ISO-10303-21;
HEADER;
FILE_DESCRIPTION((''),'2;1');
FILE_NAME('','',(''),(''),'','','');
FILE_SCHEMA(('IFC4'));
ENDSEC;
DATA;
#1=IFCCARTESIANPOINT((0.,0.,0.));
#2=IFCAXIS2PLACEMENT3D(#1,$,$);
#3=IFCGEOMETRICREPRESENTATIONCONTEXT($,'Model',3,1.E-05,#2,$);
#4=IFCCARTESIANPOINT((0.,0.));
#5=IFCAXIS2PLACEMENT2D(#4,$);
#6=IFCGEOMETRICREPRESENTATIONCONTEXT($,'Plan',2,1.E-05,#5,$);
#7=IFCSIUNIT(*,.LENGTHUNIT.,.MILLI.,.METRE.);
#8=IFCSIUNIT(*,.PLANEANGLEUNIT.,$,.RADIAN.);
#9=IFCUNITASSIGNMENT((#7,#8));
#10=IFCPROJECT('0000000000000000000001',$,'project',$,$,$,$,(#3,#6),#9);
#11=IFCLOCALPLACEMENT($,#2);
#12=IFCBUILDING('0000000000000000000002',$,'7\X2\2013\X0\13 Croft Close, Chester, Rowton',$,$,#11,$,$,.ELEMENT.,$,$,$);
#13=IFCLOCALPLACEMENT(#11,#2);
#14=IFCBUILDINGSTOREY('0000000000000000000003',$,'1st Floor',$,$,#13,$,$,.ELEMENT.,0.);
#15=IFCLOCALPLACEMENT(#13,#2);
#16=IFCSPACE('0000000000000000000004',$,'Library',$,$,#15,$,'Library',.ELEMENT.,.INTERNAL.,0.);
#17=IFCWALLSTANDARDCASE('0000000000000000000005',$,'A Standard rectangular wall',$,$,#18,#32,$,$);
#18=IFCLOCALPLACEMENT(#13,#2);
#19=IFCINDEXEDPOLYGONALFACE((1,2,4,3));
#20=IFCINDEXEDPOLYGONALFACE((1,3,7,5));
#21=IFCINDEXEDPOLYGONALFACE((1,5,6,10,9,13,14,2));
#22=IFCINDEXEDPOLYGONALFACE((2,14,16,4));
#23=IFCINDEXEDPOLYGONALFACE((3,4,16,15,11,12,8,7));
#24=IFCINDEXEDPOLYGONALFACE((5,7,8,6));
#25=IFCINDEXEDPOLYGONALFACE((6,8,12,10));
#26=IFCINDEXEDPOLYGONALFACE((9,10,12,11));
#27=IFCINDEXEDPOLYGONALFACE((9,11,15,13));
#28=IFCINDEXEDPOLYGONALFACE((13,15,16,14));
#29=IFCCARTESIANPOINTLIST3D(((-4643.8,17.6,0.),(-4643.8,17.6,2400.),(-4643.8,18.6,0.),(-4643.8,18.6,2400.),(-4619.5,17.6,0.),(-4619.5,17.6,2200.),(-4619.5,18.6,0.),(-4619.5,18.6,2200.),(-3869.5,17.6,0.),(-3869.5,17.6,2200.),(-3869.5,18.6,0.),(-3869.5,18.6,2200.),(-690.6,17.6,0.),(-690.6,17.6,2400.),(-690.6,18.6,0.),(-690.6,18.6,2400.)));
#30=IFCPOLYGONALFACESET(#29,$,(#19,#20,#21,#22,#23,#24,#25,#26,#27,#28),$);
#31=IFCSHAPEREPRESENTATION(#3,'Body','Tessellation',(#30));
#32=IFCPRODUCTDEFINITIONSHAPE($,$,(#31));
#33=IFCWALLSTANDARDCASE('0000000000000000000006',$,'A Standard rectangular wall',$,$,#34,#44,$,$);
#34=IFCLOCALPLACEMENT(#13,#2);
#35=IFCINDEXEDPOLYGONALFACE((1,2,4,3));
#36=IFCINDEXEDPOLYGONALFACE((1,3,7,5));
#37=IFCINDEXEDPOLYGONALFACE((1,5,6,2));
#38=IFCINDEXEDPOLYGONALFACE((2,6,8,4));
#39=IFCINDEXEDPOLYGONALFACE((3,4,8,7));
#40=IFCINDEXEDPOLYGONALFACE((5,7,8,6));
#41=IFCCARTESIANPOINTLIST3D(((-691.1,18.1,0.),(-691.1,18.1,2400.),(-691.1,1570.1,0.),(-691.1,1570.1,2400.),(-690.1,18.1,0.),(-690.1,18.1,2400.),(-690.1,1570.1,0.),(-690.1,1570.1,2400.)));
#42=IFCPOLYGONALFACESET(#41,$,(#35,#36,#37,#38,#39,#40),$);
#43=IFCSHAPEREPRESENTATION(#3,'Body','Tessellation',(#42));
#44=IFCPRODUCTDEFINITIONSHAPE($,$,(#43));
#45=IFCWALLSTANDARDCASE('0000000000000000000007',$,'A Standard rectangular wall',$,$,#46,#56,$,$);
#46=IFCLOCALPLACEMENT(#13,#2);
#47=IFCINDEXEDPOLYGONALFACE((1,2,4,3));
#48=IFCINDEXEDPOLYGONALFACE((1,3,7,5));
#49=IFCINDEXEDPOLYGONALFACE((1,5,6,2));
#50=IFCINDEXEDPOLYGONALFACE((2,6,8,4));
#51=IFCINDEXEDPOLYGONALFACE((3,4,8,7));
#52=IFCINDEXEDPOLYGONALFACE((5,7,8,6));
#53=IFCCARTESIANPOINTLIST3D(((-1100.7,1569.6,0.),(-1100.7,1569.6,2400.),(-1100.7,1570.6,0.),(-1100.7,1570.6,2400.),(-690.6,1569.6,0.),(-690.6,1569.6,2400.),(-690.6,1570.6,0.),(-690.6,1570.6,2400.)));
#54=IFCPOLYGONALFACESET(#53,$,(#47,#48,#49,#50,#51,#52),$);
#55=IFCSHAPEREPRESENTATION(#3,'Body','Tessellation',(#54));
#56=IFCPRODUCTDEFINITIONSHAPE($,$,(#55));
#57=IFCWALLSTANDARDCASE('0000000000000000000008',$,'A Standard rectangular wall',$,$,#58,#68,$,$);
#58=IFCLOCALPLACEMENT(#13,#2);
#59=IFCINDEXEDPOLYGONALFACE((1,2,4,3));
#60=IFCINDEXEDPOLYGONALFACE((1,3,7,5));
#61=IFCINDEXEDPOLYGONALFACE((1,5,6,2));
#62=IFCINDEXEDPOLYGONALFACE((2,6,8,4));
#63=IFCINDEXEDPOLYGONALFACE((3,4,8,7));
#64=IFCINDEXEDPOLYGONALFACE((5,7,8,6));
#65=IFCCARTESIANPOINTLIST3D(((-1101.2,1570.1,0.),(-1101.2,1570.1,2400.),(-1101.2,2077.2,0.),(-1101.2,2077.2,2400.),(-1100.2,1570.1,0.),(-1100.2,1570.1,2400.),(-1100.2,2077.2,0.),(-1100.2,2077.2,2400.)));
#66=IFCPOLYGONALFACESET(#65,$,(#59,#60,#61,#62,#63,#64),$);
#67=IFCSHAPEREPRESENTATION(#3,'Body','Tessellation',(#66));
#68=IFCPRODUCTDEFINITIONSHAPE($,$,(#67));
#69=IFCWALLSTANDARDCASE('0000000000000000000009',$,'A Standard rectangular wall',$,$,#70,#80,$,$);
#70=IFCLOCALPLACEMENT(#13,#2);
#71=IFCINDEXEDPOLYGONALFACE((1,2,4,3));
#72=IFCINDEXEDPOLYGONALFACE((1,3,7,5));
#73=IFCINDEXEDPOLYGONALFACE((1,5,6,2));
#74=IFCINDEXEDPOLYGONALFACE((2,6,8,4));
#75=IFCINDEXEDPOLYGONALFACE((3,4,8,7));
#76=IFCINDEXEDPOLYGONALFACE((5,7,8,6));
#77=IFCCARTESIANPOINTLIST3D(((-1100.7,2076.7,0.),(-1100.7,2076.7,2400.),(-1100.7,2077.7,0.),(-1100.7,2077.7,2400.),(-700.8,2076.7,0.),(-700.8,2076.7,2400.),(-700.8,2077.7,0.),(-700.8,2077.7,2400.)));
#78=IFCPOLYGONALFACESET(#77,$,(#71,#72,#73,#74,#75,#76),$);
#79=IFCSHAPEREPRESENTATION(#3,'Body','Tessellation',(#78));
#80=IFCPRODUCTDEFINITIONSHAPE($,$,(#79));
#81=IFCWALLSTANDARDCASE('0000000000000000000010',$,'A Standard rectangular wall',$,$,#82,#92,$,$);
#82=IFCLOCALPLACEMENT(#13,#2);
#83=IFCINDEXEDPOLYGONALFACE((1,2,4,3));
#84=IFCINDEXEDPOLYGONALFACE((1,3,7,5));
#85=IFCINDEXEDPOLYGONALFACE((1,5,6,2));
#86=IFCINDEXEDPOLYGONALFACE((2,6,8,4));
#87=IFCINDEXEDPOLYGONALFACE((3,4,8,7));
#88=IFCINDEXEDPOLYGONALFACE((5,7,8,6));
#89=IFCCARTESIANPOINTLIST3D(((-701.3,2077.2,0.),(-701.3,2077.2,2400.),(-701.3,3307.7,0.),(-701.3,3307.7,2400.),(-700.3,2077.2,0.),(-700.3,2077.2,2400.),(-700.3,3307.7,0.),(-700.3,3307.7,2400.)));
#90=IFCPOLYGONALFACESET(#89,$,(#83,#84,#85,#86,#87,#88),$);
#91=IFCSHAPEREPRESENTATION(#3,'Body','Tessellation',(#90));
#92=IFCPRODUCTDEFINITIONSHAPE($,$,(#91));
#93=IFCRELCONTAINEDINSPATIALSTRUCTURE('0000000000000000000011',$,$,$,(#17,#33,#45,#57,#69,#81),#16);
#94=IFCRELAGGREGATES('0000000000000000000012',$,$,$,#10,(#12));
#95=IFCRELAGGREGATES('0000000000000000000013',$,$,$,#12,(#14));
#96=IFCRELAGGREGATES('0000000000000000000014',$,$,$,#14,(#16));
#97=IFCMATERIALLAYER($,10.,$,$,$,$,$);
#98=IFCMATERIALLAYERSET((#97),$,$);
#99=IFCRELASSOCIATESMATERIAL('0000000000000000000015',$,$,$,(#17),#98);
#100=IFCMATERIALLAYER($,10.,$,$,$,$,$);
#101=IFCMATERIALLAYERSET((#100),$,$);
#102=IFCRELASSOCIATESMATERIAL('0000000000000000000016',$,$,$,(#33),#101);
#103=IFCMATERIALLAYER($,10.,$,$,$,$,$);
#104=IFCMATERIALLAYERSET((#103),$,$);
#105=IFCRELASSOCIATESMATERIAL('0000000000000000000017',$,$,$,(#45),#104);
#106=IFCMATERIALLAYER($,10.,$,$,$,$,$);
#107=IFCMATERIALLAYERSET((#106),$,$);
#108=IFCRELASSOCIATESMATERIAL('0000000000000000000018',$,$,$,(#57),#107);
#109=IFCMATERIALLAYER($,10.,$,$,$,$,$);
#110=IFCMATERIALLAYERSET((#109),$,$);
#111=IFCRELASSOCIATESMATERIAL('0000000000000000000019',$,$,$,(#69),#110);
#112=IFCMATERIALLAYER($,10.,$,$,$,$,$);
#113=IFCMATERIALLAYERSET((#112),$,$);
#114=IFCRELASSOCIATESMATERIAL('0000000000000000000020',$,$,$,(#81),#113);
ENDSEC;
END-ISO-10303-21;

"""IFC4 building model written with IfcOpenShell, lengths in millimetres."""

from ifc_helpers import new_model, si_unit, frame, origin, origin_2d, place, context, project, spatial, rectangle, extrude, layer, layer_set, layer_usage, element, save


model = new_model("IFC4")

# Units and contexts
model_context = context("Model", 3, precision=1e-05, world=origin())
plan_context = context("Plan", 2, precision=1e-05, world=origin_2d())
ifc_project = project(units=[si_unit("LENGTHUNIT", "METRE", prefix="MILLI"), si_unit("PLANEANGLEUNIT", "RADIAN")], contexts=[model_context, plan_context])

# Building, storey, space
building_placement = place(None, origin())
building = spatial("IfcBuilding", under=ifc_project, at=building_placement, Name="7–13 Croft Close, Chester, Rowton", CompositionType="ELEMENT")
storey_placement = place(building_placement, origin())
storey = spatial("IfcBuildingStorey", under=building, at=storey_placement, Name="1st Floor", CompositionType="ELEMENT", Elevation=0.0)
space_1_placement = place(storey_placement, origin())
space_1 = spatial("IfcSpace", under=storey, at=space_1_placement, Name="Library", LongName="Library", CompositionType="ELEMENT", PredefinedType="INTERNAL", ElevationWithFlooring=0.0)

# Wall, opening
ifc_layer_1 = layer(None, 10.0)
ifc_layer_set_1 = layer_set([ifc_layer_1])
ifc_layer_usage_1 = layer_usage(ifc_layer_set_1, "AXIS2", "NEGATIVE", 150.0)
wall_1_placement = place(storey_placement, origin())
wall_1 = element("IfcWallStandardCase", 1, at=wall_1_placement, inside=space_1, material=ifc_layer_usage_1, Name="A Standard rectangular wall", context=model_context, shape_type="SweptSolid", body=[
    extrude(rectangle(XDim=1.0, YDim=3953.2, at=origin_2d()), frame((-2667.2, 18.1, 0.0), x_axis=(0.0, 1.0, 0.0)), (0.0, 0.0, 1.0), 2400.0),
])
opening_1_placement = place(storey_placement, origin())
element("IfcOpeningElement", 2, at=opening_1_placement, cuts=wall_1, context=model_context, shape_type="SweptSolid", body=[
    extrude(rectangle(XDim=10.0, YDim=750.0, at=origin_2d()), frame((-4244.5, 18.1, 0.0), x_axis=(0.0, -1.0, 0.0)), (0.0, 0.0, 1.0), 2200.0),
])

# Walls
ifc_layer_2 = layer(None, 10.0)
ifc_layer_set_2 = layer_set([ifc_layer_2])
ifc_layer_usage_2 = layer_usage(ifc_layer_set_2, "AXIS2", "NEGATIVE", 150.0)
wall_2_placement = place(storey_placement, origin())
element("IfcWallStandardCase", 3, at=wall_2_placement, inside=space_1, material=ifc_layer_usage_2, Name="A Standard rectangular wall", context=model_context, shape_type="SweptSolid", body=[
    extrude(rectangle(XDim=1.0, YDim=1552.0, at=origin_2d()), frame((-690.6, 794.1, 0.0), x_axis=(-1.0, 0.0, 0.0)), (0.0, 0.0, 1.0), 2400.0),
])
ifc_layer_3 = layer(None, 10.0)
ifc_layer_set_3 = layer_set([ifc_layer_3])
ifc_layer_usage_3 = layer_usage(ifc_layer_set_3, "AXIS2", "NEGATIVE", 150.0)
wall_3_placement = place(storey_placement, origin())
element("IfcWallStandardCase", 4, at=wall_3_placement, inside=space_1, material=ifc_layer_usage_3, Name="A Standard rectangular wall", context=model_context, shape_type="SweptSolid", body=[
    extrude(rectangle(XDim=1.0, YDim=410.1, at=origin_2d()), frame((-895.7, 1570.1, 0.0), x_axis=(0.0, -1.0, 0.0)), (0.0, 0.0, 1.0), 2400.0),
])
ifc_layer_4 = layer(None, 10.0)
ifc_layer_set_4 = layer_set([ifc_layer_4])
ifc_layer_usage_4 = layer_usage(ifc_layer_set_4, "AXIS2", "NEGATIVE", 150.0)
wall_4_placement = place(storey_placement, origin())
element("IfcWallStandardCase", 5, at=wall_4_placement, inside=space_1, material=ifc_layer_usage_4, Name="A Standard rectangular wall", context=model_context, shape_type="SweptSolid", body=[
    extrude(rectangle(XDim=1.0, YDim=507.1, at=origin_2d()), frame((-1100.7, 1823.6, 0.0), x_axis=(-1.0, 0.0, 0.0)), (0.0, 0.0, 1.0), 2400.0),
])
ifc_layer_5 = layer(None, 10.0)
ifc_layer_set_5 = layer_set([ifc_layer_5])
ifc_layer_usage_5 = layer_usage(ifc_layer_set_5, "AXIS2", "NEGATIVE", 150.0)
wall_5_placement = place(storey_placement, origin())
element("IfcWallStandardCase", 6, at=wall_5_placement, inside=space_1, material=ifc_layer_usage_5, Name="A Standard rectangular wall", context=model_context, shape_type="SweptSolid", body=[
    extrude(rectangle(XDim=1.0, YDim=399.9, at=origin_2d()), frame((-900.8, 2077.2, 0.0), x_axis=(0.0, 1.0, 0.0)), (0.0, 0.0, 1.0), 2400.0),
])
ifc_layer_6 = layer(None, 10.0)
ifc_layer_set_6 = layer_set([ifc_layer_6])
ifc_layer_usage_6 = layer_usage(ifc_layer_set_6, "AXIS2", "NEGATIVE", 150.0)
wall_6_placement = place(storey_placement, origin())
element("IfcWallStandardCase", 7, at=wall_6_placement, inside=space_1, material=ifc_layer_usage_6, Name="A Standard rectangular wall", context=model_context, shape_type="SweptSolid", body=[
    extrude(rectangle(XDim=1.0, YDim=1230.5, at=origin_2d()), frame((-700.8, 2692.4, 0.0), x_axis=(-1.0, 0.0, 0.0)), (0.0, 0.0, 1.0), 2400.0),
])

save(model, "model.ifc")
